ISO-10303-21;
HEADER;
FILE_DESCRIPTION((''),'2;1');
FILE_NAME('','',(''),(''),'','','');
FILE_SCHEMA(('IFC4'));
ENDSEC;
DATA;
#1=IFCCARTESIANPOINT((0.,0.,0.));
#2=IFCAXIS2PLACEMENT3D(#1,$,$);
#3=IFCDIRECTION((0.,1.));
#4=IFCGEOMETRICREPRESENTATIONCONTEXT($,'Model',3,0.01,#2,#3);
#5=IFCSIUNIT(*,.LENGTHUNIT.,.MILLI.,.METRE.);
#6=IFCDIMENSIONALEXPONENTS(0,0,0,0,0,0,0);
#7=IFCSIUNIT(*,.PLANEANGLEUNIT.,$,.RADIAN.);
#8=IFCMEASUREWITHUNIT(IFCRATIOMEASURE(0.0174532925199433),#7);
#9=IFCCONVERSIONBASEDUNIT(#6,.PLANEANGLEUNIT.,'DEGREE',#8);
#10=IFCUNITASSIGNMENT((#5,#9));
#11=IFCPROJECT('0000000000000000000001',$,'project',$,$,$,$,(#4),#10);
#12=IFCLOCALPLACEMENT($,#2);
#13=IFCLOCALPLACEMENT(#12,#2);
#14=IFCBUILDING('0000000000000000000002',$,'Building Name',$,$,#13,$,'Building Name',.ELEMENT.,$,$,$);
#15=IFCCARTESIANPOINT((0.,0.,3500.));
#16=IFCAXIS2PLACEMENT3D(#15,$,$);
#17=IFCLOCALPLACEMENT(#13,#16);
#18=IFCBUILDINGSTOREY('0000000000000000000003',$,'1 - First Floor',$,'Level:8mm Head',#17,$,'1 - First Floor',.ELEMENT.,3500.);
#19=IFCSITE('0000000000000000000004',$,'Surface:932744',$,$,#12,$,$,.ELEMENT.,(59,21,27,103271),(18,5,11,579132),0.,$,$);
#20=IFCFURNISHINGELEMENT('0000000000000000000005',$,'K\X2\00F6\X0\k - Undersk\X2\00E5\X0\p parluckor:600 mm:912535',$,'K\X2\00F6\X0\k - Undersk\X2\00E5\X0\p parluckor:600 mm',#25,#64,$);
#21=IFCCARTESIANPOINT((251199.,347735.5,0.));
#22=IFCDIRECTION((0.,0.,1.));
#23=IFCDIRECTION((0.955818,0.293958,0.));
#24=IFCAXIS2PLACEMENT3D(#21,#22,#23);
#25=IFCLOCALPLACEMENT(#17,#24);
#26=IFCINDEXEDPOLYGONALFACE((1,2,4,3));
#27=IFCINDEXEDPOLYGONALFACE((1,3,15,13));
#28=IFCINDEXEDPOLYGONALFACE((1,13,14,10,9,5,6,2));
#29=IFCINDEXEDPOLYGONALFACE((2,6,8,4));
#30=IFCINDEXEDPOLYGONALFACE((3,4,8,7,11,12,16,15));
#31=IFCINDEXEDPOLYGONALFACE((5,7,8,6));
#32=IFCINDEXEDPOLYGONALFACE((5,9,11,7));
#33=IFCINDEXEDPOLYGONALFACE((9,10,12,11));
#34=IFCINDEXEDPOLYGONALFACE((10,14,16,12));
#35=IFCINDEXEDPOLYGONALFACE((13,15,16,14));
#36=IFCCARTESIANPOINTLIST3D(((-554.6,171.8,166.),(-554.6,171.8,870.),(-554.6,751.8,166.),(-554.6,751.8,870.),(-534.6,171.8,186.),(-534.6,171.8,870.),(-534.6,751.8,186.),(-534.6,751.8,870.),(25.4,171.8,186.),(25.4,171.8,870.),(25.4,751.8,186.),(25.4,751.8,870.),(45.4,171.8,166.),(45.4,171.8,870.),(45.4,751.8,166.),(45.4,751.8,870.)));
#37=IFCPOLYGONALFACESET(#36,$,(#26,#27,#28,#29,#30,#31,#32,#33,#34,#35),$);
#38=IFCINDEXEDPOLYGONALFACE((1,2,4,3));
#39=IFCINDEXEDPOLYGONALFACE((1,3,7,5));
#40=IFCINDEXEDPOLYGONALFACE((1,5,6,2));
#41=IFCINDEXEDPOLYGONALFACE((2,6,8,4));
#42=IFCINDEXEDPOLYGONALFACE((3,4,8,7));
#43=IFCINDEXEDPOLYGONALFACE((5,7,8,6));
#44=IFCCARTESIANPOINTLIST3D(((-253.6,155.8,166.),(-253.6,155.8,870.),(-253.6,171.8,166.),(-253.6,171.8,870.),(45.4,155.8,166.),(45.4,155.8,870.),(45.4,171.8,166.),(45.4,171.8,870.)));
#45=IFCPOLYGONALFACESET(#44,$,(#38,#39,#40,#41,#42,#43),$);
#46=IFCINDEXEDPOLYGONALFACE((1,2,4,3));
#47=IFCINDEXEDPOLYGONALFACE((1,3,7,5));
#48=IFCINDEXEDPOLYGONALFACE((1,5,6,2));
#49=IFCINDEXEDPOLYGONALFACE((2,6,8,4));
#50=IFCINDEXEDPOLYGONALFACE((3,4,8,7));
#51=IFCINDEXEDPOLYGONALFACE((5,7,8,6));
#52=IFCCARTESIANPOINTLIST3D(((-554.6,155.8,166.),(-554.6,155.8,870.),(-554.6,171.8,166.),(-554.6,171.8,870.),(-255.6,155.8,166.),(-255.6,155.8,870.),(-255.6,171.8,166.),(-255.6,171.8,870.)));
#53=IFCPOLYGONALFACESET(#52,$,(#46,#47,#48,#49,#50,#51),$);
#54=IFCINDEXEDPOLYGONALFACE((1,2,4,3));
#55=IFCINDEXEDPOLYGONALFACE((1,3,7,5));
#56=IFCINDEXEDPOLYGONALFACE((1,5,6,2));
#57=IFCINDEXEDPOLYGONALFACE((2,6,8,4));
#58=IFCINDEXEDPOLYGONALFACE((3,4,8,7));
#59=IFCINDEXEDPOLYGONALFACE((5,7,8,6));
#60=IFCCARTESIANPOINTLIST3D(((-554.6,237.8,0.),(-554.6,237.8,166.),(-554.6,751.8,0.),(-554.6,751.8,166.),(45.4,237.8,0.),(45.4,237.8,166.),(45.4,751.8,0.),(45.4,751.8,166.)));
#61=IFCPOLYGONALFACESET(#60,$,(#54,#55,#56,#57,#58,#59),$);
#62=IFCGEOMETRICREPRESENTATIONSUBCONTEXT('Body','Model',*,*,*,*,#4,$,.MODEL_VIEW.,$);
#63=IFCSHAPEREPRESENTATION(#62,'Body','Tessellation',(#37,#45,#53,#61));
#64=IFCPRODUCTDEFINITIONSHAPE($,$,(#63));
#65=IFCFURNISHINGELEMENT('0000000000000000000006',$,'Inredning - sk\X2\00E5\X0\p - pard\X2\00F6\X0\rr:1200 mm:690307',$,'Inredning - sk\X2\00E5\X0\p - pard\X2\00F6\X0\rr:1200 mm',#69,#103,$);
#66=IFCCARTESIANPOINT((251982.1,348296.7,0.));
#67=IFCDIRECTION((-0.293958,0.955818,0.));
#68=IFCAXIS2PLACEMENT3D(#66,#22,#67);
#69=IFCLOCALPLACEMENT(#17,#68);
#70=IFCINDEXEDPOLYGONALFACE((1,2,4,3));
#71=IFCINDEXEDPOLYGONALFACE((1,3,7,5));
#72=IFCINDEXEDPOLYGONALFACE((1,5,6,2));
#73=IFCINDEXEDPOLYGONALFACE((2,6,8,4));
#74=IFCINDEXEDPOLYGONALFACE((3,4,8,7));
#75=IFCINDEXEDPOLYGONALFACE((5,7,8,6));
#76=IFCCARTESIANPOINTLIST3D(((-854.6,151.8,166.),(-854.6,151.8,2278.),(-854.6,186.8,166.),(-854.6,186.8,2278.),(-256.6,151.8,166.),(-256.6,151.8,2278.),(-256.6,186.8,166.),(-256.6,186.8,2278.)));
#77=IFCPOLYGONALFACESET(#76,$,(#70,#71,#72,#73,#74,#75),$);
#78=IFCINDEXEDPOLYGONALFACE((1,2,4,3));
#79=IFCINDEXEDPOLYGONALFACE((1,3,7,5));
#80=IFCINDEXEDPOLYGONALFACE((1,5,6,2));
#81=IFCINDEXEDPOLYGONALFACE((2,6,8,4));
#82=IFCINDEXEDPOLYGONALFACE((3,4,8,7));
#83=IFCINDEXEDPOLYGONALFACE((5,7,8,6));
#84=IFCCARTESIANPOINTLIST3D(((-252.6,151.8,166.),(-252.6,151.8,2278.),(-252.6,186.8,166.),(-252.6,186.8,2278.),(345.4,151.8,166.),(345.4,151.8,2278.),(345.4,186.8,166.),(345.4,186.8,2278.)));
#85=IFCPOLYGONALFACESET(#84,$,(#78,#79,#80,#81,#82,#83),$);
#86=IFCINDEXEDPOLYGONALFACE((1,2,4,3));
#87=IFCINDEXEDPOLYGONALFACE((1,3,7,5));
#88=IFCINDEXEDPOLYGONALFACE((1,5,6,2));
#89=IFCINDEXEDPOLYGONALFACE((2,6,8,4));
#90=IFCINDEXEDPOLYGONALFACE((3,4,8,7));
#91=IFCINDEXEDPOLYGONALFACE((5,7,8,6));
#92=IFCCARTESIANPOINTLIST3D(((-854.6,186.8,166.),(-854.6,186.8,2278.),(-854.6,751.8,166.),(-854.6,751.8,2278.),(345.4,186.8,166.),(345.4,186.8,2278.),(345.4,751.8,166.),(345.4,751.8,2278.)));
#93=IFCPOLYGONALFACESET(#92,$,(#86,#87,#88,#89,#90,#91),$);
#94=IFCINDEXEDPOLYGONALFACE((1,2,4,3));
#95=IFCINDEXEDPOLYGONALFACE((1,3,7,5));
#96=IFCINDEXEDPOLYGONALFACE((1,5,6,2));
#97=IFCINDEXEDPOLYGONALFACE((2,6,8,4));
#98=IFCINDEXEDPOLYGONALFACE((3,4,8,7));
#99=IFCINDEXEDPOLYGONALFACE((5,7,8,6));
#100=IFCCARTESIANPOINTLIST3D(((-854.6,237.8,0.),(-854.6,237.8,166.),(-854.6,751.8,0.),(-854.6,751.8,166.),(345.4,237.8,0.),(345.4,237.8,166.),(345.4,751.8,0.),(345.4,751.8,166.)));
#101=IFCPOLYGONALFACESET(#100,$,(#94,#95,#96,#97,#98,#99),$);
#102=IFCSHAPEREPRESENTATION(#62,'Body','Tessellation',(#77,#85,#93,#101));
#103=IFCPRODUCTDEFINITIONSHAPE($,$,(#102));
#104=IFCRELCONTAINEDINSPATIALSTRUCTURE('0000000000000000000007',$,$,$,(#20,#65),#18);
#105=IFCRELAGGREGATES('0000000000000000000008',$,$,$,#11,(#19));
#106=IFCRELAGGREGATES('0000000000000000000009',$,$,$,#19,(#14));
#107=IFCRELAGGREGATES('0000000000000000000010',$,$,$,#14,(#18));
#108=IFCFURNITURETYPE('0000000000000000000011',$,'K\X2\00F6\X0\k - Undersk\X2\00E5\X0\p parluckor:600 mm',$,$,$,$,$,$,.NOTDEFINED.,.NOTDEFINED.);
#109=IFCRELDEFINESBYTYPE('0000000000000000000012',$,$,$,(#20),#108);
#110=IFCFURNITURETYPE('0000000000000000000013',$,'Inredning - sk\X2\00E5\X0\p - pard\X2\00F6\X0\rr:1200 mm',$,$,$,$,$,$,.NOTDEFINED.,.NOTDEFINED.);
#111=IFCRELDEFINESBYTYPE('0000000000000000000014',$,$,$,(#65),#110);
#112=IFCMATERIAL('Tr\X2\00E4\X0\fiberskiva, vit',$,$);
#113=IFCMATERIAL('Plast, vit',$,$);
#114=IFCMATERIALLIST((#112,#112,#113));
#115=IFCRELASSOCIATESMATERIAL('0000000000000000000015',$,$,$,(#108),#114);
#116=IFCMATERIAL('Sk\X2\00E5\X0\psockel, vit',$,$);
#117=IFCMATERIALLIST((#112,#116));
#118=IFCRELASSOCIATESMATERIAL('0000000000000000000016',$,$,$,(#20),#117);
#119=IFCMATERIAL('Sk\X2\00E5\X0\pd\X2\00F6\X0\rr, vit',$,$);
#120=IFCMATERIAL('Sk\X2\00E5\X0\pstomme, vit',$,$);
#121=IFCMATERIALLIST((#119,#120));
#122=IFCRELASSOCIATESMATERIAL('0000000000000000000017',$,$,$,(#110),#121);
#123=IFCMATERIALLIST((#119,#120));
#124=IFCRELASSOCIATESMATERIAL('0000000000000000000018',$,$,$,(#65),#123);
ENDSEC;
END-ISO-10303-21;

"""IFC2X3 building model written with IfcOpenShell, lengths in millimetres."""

from ifc_helpers import new_model, entity, si_unit, converted_unit, direction, frame, frame_2d, origin, origin_2d_with_axis, place, context, subcontext, project, spatial, polyline, rectangle, outline, extrude, source, transform, mapped, material, material_list, type_object, type_shapes, element, save


model = new_model("IFC2X3")

# Units and contexts
model_context = context("Model", 3, precision=0.01, world=origin(), true_north=direction((0.0, 1.0)))
body_context = subcontext(model_context, "Body", "Model", "MODEL_VIEW")
ifc_project = project(units=[si_unit("LENGTHUNIT", "METRE", prefix="MILLI"), converted_unit("PLANEANGLEUNIT", "DEGREE", entity("IfcRatioMeasure", 0.0174532925199433), si_unit("PLANEANGLEUNIT", "RADIAN"), dimensions=[0, 0, 0, 0, 0, 0, 0])], contexts=[model_context])

# Site, building, storey
site_placement = place(None, origin())
site = spatial("IfcSite", under=ifc_project, at=site_placement, Name="Surface:932744", CompositionType="ELEMENT", RefLatitude=(59, 21, 27, 103271), RefLongitude=(18, 5, 11, 579132), RefElevation=0.0)
building_placement = place(site_placement, origin())
building = spatial("IfcBuilding", under=site, at=building_placement, Name="Building Name", LongName="Building Name", CompositionType="ELEMENT")
storey_placement = place(building_placement, frame((0.0, 0.0, 3500.0)))
storey = spatial("IfcBuildingStorey", under=building, at=storey_placement, Name="1 - First Floor", ObjectType="Level:8mm Head", LongName="1 - First Floor", CompositionType="ELEMENT", Elevation=3500.0)

# Furnishing elements
ifc_material_1 = material(Name="Träfiberskiva, vit")
ifc_material_2 = material(Name="Skåpsockel, vit")
ifc_material_list_1 = material_list([ifc_material_1, ifc_material_2])
ifc_material_3 = material(Name="Plast, vit")
ifc_material_list_2 = material_list([ifc_material_1, ifc_material_1, ifc_material_3])
furniture_type_1 = type_object("IfcFurnitureType", Name="Kök - Underskåp parluckor:600 mm", material=ifc_material_list_2)
shared_shape_1 = source(origin(), body_context, "Body", "SweptSolid", [
    extrude(outline(polyline([(-300.0, -347.0), (-280.0, -347.0), (-280.0, 337.0), (280.0, 337.0), (280.0, -347.0), (300.0, -347.0), (300.0, 357.0), (-300.0, 357.0), (-300.0, -347.0)])), frame((-254.6, 171.8, 523.0), z_axis=(0.0, 1.0, 0.0), x_axis=(1.0, 0.0, 0.0)), (0.0, 0.0, 1.0), 580.0),
    extrude(rectangle(XDim=16.0, YDim=299.0, at=frame_2d((0.0, 0.0), x_axis=(1.0, 0.0))), frame((-104.1, 163.8, 166.0), z_axis=(0.0, 0.0, 1.0), x_axis=(0.0, 1.0, 0.0)), (0.0, 0.0, 1.0), 704.0),
    extrude(rectangle(XDim=16.0, YDim=299.0, at=frame_2d((0.0, 0.0), x_axis=(1.0, 0.0))), frame((-405.1, 163.8, 166.0), z_axis=(0.0, 0.0, 1.0), x_axis=(0.0, 1.0, 0.0)), (0.0, 0.0, 1.0), 704.0),
    extrude(rectangle(XDim=600.0, YDim=514.0, at=frame_2d((0.0, 0.0), x_axis=(1.0, 0.0))), frame((-254.6, 494.8, 0.0), z_axis=(0.0, 0.0, 1.0), x_axis=(-1.0, 0.0, 0.0)), (0.0, 0.0, 1.0), 166.0),
])
type_shapes(furniture_type_1, [shared_shape_1])
furnishing_1_placement = place(storey_placement, frame((251199.0, 347735.5, 0.0), z_axis=(0.0, 0.0, 1.0), x_axis=(0.955818, 0.293958, 0.0)))
element("IfcFurnishingElement", 1, at=furnishing_1_placement, inside=storey, type_object=furniture_type_1, material=ifc_material_list_1, Name="Kök - Underskåp parluckor:600 mm:912535", ObjectType="Kök - Underskåp parluckor:600 mm", context=body_context, shape_type="MappedRepresentation", body=[
    mapped(shared_shape_1, transform((0.0, 0.0, 0.0), scale=1.0)),
])
ifc_material_4 = material(Name="Skåpdörr, vit")
ifc_material_5 = material(Name="Skåpstomme, vit")
ifc_material_list_3 = material_list([ifc_material_4, ifc_material_5])
ifc_material_list_4 = material_list([ifc_material_4, ifc_material_5])
furniture_type_2 = type_object("IfcFurnitureType", Name="Inredning - skåp - pardörr:1200 mm", material=ifc_material_list_4)
shared_shape_2 = source(origin(), body_context, "Body", "SweptSolid", [
    extrude(rectangle(XDim=35.0, YDim=598.0, at=frame_2d((0.0, 0.0), x_axis=(1.0, 0.0))), frame((-555.6, 169.3, 166.0), z_axis=(0.0, 0.0, 1.0), x_axis=(0.0, -1.0, 0.0)), (0.0, 0.0, 1.0), 2112.0),
    extrude(rectangle(XDim=35.0, YDim=598.0, at=frame_2d((0.0, 0.0), x_axis=(1.0, 0.0))), frame((46.4, 169.3, 166.0), z_axis=(0.0, 0.0, 1.0), x_axis=(0.0, -1.0, 0.0)), (0.0, 0.0, 1.0), 2112.0),
    extrude(rectangle(XDim=1200.0, YDim=565.0, at=origin_2d_with_axis()), frame((-254.6, 469.3, 166.0), z_axis=(0.0, 0.0, 1.0), x_axis=(-1.0, 0.0, 0.0)), (0.0, 0.0, 1.0), 2112.0),
    extrude(rectangle(XDim=1200.0, YDim=514.0, at=frame_2d((0.0, 0.0), x_axis=(1.0, 0.0))), frame((-254.6, 494.8, 0.0), z_axis=(0.0, 0.0, 1.0), x_axis=(-1.0, 0.0, 0.0)), (0.0, 0.0, 1.0), 166.0),
])
type_shapes(furniture_type_2, [shared_shape_2])
furnishing_2_placement = place(storey_placement, frame((251982.1, 348296.7, 0.0), z_axis=(0.0, 0.0, 1.0), x_axis=(-0.293958, 0.955818, 0.0)))
element("IfcFurnishingElement", 2, at=furnishing_2_placement, inside=storey, type_object=furniture_type_2, material=ifc_material_list_3, Name="Inredning - skåp - pardörr:1200 mm:690307", ObjectType="Inredning - skåp - pardörr:1200 mm", context=body_context, shape_type="MappedRepresentation", body=[
    mapped(shared_shape_2, transform((0.0, 0.0, 0.0), scale=1.0)),
])

save(model, "model.ifc")
